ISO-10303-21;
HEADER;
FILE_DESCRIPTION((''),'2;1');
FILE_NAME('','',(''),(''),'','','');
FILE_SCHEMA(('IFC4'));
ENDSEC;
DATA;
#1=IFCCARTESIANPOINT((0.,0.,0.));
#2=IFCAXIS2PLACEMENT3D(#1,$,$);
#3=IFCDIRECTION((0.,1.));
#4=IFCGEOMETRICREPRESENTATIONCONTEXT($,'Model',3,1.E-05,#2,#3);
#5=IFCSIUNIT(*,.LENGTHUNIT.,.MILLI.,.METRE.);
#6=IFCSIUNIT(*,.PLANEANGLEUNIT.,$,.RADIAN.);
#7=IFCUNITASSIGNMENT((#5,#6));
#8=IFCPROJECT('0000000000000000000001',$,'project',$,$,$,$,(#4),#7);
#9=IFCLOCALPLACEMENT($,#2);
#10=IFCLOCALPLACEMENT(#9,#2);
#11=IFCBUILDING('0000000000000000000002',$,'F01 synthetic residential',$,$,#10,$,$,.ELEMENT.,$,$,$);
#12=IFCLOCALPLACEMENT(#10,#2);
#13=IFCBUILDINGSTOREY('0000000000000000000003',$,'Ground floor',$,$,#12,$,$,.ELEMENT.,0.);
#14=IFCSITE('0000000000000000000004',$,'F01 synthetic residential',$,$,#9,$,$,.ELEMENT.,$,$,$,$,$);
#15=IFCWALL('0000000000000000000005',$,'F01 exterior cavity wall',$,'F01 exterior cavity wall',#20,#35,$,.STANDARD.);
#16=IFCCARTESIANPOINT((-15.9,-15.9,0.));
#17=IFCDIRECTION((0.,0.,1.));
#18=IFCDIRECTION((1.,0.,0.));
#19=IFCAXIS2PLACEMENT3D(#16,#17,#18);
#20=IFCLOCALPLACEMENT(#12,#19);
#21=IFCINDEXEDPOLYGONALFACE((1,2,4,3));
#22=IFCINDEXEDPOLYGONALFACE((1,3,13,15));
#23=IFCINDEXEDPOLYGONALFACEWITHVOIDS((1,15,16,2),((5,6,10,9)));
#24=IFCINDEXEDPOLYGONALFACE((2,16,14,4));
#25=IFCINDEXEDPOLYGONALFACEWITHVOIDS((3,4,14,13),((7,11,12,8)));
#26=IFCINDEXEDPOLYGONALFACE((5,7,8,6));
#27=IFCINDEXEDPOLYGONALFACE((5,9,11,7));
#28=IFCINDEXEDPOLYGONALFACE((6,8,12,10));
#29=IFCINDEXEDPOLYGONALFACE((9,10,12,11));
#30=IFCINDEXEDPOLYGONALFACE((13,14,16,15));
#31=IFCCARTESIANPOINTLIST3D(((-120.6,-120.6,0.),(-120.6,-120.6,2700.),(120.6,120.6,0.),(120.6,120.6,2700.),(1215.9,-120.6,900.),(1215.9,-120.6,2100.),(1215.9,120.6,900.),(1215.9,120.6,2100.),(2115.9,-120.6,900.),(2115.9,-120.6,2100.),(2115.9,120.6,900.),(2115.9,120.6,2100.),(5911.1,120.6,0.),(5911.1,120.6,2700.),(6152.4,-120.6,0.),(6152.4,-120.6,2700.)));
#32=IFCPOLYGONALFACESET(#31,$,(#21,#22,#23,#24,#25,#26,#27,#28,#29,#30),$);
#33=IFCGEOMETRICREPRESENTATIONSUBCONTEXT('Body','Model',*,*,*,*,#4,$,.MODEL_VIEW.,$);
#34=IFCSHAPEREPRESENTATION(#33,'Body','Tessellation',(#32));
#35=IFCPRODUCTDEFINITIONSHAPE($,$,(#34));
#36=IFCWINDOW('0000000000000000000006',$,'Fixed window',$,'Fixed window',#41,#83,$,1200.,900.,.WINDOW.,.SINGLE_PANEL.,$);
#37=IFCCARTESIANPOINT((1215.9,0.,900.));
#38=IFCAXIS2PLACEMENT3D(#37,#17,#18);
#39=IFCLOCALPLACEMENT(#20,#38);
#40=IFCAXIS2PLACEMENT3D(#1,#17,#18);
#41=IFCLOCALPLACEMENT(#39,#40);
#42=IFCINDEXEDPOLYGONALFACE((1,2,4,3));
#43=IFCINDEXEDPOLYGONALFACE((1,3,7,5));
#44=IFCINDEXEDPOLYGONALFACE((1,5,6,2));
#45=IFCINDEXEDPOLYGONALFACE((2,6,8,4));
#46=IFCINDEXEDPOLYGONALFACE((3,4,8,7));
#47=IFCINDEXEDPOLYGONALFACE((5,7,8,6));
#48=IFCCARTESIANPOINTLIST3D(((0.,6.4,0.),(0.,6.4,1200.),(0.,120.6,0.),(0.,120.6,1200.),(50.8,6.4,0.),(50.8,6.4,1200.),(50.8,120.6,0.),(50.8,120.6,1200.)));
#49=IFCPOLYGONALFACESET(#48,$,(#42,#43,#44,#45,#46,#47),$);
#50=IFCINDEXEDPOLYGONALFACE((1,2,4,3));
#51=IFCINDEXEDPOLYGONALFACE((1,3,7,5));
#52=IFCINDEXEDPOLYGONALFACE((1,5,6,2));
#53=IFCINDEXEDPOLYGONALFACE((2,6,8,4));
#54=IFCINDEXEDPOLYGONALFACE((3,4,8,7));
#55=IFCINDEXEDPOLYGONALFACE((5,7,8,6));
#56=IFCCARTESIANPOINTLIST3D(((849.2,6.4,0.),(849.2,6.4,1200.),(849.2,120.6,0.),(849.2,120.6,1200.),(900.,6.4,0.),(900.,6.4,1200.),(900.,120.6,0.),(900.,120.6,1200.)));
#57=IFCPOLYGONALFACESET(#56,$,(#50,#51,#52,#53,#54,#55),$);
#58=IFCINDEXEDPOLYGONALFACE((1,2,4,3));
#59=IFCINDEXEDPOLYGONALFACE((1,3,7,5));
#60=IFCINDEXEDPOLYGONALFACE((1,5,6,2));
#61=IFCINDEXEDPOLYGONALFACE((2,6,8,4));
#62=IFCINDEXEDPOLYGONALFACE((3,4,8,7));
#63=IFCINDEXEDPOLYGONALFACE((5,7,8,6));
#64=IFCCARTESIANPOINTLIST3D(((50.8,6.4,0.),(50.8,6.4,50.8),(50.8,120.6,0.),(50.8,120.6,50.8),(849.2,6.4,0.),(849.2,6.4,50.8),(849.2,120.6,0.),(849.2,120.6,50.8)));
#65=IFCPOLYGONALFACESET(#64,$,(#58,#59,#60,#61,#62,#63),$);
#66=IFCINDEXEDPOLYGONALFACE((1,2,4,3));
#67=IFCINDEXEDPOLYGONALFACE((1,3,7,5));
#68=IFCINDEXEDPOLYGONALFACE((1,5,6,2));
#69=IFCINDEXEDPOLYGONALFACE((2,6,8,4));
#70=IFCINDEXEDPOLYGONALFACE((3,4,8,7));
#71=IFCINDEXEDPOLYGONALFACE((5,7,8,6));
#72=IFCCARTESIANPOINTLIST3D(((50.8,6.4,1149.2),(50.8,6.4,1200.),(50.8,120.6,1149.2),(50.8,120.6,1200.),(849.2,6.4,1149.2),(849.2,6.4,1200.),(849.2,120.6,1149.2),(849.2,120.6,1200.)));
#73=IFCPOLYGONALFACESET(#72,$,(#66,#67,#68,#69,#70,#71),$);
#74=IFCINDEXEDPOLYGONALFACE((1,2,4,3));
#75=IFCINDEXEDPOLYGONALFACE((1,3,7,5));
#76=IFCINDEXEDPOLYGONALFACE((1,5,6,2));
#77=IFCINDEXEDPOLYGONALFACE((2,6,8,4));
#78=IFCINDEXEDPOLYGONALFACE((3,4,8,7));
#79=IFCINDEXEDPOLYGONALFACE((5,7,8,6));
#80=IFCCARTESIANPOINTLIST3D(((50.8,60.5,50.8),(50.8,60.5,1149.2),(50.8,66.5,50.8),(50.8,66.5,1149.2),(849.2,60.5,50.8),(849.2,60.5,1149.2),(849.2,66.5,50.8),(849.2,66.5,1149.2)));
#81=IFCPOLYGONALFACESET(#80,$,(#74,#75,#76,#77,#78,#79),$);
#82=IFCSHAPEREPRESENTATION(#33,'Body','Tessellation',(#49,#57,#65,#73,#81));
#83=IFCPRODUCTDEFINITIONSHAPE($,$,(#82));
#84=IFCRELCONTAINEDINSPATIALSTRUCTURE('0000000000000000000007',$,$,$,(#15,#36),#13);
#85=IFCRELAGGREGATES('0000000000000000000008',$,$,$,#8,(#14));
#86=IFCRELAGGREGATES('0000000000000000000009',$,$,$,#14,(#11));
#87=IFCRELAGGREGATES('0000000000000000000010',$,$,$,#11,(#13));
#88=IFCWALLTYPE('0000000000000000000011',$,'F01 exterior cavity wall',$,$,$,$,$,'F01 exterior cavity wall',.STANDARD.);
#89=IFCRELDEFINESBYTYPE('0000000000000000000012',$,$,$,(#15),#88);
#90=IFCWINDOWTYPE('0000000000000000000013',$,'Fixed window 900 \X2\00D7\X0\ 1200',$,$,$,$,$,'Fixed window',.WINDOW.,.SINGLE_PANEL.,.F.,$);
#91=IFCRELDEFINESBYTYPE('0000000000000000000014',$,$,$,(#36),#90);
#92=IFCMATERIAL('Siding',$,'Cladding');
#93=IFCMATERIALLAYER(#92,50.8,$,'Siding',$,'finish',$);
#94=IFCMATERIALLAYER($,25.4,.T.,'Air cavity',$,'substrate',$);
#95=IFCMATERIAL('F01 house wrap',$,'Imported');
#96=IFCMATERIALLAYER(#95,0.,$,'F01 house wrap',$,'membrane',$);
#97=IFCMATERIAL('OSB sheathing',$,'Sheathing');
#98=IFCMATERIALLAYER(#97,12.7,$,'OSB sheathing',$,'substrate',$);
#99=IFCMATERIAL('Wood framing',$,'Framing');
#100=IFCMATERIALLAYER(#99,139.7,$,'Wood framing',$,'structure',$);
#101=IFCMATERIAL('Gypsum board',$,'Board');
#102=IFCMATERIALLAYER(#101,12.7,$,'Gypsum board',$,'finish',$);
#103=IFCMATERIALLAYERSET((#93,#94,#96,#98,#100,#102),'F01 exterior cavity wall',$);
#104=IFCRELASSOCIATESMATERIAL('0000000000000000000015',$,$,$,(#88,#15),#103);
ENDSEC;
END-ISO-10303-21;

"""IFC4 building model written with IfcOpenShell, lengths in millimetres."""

from ifc_helpers import new_model, si_unit, direction, frame, origin, origin_with_axes, place, context, subcontext, project, spatial, polyline, outline, extrude, material, layer, layer_set, layer_usage, type_object, element, fill, save


model = new_model("IFC4")

# Units and contexts
model_context = context("Model", 3, precision=1e-05, world=origin(), true_north=direction((0.0, 1.0)))
body_context = subcontext(model_context, "Body", "Model", "MODEL_VIEW")
ifc_project = project(units=[si_unit("LENGTHUNIT", "METRE", prefix="MILLI"), si_unit("PLANEANGLEUNIT", "RADIAN")], contexts=[model_context])

# Site, building, storey
site_placement = place(None, origin())
site = spatial("IfcSite", under=ifc_project, at=site_placement, Name="F01 synthetic residential", CompositionType="ELEMENT")
building_placement = place(site_placement, origin())
building = spatial("IfcBuilding", under=site, at=building_placement, Name="F01 synthetic residential", CompositionType="ELEMENT")
storey_placement = place(building_placement, origin())
storey = spatial("IfcBuildingStorey", under=building, at=storey_placement, Name="Ground floor", CompositionType="ELEMENT", Elevation=0.0)

# Wall, opening, window
ifc_material_1 = material(Name="Siding", Category="Cladding")
ifc_layer_1 = layer(ifc_material_1, 50.8, Name="Siding", Category="finish")
ifc_layer_2 = layer(None, 25.4, ventilated=True, Name="Air cavity", Category="substrate")
ifc_material_2 = material(Name="F01 house wrap", Category="Imported")
ifc_layer_3 = layer(ifc_material_2, 0.0, Name="F01 house wrap", Category="membrane")
ifc_material_3 = material(Name="OSB sheathing", Category="Sheathing")
ifc_layer_4 = layer(ifc_material_3, 12.7, Name="OSB sheathing", Category="substrate")
ifc_material_4 = material(Name="Wood framing", Category="Framing")
ifc_layer_5 = layer(ifc_material_4, 139.7, Name="Wood framing", Category="structure")
ifc_material_5 = material(Name="Gypsum board", Category="Board")
ifc_layer_6 = layer(ifc_material_5, 12.7, Name="Gypsum board", Category="finish")
ifc_layer_set_1 = layer_set([ifc_layer_1, ifc_layer_2, ifc_layer_3, ifc_layer_4, ifc_layer_5, ifc_layer_6], Name="F01 exterior cavity wall")
ifc_layer_usage_1 = layer_usage(ifc_layer_set_1, "AXIS2", "POSITIVE", -120.7)
wall_type_1 = type_object("IfcWallType", Name="F01 exterior cavity wall", ElementType="F01 exterior cavity wall", PredefinedType="STANDARD", material=ifc_layer_set_1)
wall_1_placement = place(storey_placement, frame((-15.9, -15.9, 0.0), z_axis=(0.0, 0.0, 1.0), x_axis=(1.0, 0.0, 0.0)))
wall_1 = element("IfcWall", 1, at=wall_1_placement, inside=storey, type_object=wall_type_1, material=ifc_layer_usage_1, Name="F01 exterior cavity wall", ObjectType="F01 exterior cavity wall", PredefinedType="STANDARD", context=body_context, shape_type="SweptSolid", body=[
    extrude(outline(polyline([(-120.7, -120.7), (6152.4, -120.7), (5911.1, 120.7), (120.7, 120.7), (-120.7, -120.7)])), origin(), (0.0, 0.0, 1.0), 2700.0),
])
opening_placement = place(wall_1_placement, frame((1215.9, 0.0, 900.0), z_axis=(0.0, 0.0, 1.0), x_axis=(1.0, 0.0, 0.0)))
opening = element("IfcOpeningElement", 2, at=opening_placement, cuts=wall_1, PredefinedType="OPENING", context=body_context, shape_type="SweptSolid", body=[
    extrude(outline(polyline([(0.0, -130.7), (900.0, -130.7), (900.0, 130.7), (0.0, 130.7), (0.0, -130.7)])), origin(), (0.0, 0.0, 1.0), 1200.0),
])
window_type = type_object("IfcWindowType", Name="Fixed window 900 × 1200", ElementType="Fixed window", ParameterTakesPrecedence=False, PartitioningType="SINGLE_PANEL", PredefinedType="WINDOW")
window_placement = place(opening_placement, origin_with_axes())
window = element("IfcWindow", 3, at=window_placement, inside=storey, type_object=window_type, Name="Fixed window", ObjectType="Fixed window", OverallHeight=1200.0, OverallWidth=900.0, PartitioningType="SINGLE_PANEL", PredefinedType="WINDOW", context=body_context, shape_type="SweptSolid", body=[
    extrude(outline(polyline([(0.0, 6.3), (50.8, 6.3), (50.8, 120.7), (0.0, 120.7), (0.0, 6.3)])), origin(), (0.0, 0.0, 1.0), 1200.0),
    extrude(outline(polyline([(849.2, 6.3), (900.0, 6.3), (900.0, 120.7), (849.2, 120.7), (849.2, 6.3)])), origin(), (0.0, 0.0, 1.0), 1200.0),
    extrude(outline(polyline([(50.8, 6.3), (849.2, 6.3), (849.2, 120.7), (50.8, 120.7), (50.8, 6.3)])), origin(), (0.0, 0.0, 1.0), 50.8),
    extrude(outline(polyline([(50.8, 6.3), (849.2, 6.3), (849.2, 120.7), (50.8, 120.7), (50.8, 6.3)])), frame((0.0, 0.0, 1149.2)), (0.0, 0.0, 1.0), 50.8),
    extrude(outline(polyline([(50.8, 60.5), (849.2, 60.5), (849.2, 66.5), (50.8, 66.5), (50.8, 60.5)])), frame((0.0, 0.0, 50.8)), (0.0, 0.0, 1.0), 1098.4),
])
fill(opening, window)

save(model, "model.ifc")
